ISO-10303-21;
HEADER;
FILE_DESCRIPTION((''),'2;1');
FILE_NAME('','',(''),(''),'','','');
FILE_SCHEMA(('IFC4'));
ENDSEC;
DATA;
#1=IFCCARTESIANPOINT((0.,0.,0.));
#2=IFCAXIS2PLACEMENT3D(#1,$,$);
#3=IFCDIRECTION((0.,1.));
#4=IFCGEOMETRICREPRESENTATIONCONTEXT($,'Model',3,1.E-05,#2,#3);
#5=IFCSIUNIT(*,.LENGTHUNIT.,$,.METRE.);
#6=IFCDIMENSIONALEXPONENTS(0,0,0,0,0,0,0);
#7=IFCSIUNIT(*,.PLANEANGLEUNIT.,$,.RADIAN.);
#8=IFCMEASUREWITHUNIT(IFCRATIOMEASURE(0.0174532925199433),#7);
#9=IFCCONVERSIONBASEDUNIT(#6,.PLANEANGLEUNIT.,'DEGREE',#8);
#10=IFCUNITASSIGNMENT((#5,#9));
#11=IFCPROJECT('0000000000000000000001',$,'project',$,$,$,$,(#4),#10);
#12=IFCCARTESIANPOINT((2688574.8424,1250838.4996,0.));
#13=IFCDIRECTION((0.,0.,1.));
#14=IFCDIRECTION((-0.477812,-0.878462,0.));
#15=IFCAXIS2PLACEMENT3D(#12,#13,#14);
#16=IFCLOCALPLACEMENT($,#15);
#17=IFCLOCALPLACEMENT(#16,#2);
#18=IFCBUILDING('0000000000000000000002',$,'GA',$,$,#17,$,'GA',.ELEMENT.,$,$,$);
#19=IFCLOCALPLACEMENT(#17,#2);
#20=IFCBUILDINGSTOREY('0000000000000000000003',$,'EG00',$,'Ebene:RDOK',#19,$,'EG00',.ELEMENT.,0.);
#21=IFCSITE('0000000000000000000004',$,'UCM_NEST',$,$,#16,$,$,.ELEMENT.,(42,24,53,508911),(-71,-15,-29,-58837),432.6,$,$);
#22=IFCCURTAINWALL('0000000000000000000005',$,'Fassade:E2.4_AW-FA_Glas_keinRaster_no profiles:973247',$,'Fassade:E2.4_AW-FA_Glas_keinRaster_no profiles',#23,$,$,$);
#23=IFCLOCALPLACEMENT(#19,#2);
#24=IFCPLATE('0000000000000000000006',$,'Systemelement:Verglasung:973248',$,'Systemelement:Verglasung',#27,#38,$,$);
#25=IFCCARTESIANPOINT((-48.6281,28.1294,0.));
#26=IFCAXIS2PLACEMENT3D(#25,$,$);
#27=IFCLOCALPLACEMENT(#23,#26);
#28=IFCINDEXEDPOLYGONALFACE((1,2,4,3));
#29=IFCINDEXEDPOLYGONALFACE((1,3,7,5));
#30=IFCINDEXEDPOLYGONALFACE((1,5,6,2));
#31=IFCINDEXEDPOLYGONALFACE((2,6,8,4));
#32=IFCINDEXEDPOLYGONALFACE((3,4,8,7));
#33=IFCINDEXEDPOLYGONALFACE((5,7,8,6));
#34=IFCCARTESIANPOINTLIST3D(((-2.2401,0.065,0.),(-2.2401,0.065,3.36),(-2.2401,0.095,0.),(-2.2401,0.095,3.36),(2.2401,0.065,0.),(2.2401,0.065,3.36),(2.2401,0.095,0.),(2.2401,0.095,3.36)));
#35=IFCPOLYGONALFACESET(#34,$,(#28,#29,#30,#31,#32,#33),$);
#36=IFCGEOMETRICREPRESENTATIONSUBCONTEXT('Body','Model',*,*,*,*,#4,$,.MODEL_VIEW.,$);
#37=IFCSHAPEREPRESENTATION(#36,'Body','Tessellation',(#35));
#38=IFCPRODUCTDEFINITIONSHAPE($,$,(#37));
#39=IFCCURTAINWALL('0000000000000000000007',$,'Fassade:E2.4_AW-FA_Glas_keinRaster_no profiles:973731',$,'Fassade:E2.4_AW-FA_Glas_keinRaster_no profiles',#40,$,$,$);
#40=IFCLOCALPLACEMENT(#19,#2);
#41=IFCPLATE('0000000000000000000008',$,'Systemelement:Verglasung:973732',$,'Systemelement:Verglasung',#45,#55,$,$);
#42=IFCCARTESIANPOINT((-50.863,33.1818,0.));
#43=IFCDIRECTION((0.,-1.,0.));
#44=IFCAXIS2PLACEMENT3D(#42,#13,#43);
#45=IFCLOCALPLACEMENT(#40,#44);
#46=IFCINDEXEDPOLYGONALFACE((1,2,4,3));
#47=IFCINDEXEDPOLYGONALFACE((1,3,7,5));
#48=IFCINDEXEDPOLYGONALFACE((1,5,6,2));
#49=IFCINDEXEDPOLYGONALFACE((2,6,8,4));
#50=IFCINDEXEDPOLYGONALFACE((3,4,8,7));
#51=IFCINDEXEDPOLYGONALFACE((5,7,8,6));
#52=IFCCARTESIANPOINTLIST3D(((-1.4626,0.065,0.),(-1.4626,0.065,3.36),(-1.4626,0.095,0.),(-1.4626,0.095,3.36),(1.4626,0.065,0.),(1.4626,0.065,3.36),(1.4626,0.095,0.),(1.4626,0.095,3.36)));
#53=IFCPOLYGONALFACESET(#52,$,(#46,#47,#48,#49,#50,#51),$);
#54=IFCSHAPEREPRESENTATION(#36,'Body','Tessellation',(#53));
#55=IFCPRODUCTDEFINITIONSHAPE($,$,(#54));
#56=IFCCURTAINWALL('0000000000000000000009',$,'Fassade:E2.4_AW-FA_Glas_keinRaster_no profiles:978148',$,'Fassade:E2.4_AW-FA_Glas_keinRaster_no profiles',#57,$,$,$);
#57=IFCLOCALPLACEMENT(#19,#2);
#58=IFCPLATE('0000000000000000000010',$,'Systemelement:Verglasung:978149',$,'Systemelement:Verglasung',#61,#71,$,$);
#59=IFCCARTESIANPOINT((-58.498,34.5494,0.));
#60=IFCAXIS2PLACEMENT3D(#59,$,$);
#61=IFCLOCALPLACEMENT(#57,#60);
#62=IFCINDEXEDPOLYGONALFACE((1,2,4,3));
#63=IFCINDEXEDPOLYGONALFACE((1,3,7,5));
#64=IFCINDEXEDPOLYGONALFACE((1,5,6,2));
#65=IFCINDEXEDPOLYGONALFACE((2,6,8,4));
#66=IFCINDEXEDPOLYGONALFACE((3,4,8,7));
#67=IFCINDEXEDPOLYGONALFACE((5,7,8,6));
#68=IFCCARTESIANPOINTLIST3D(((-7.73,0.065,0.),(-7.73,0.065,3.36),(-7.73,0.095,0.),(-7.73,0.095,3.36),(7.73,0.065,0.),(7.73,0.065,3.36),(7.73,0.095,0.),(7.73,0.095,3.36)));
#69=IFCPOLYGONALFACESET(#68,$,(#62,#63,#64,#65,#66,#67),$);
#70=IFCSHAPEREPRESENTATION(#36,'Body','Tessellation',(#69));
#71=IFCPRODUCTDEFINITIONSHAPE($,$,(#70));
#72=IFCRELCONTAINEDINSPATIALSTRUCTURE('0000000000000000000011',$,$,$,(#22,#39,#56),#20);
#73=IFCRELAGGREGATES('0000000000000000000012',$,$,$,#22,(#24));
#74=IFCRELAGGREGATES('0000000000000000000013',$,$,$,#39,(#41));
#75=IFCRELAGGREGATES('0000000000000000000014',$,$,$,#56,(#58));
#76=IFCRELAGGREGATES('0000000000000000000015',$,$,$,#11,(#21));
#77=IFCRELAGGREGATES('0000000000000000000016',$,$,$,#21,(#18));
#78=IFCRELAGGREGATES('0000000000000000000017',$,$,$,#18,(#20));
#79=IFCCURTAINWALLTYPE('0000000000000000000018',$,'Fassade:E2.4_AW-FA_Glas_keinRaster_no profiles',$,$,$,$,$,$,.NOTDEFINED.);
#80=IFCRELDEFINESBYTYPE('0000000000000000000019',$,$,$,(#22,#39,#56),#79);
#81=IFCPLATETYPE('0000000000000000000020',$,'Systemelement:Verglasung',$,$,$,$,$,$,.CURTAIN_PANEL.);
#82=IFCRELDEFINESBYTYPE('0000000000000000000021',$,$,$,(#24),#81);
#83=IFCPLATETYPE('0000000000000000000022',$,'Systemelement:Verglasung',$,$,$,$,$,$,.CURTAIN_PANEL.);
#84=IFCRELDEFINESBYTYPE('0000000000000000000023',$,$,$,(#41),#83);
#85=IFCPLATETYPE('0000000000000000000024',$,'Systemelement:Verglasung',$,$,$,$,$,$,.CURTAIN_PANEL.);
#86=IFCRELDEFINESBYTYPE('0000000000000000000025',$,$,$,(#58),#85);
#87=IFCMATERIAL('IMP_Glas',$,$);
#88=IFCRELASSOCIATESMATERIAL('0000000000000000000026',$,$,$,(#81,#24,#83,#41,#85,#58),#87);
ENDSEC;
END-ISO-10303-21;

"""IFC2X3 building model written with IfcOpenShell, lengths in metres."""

from ifc_helpers import new_model, entity, si_unit, converted_unit, direction, frame, frame_2d, origin, place, context, subcontext, project, spatial, rectangle, extrude, source, transform, mapped, material, type_object, type_shapes, element, aggregate, save


model = new_model("IFC2X3")

# Units and contexts
model_context = context("Model", 3, precision=1e-05, world=origin(), true_north=direction((0.0, 1.0)))
body_context = subcontext(model_context, "Body", "Model", "MODEL_VIEW")
ifc_project = project(units=[si_unit("LENGTHUNIT", "METRE"), converted_unit("PLANEANGLEUNIT", "DEGREE", entity("IfcRatioMeasure", 0.0174532925199433), si_unit("PLANEANGLEUNIT", "RADIAN"), dimensions=[0, 0, 0, 0, 0, 0, 0])], contexts=[model_context])

# Site, building, storey
site_placement = place(None, frame((2688574.8424, 1250838.4996, 0.0), z_axis=(0.0, 0.0, 1.0), x_axis=(-0.477812, -0.878462, 0.0)))
site = spatial("IfcSite", under=ifc_project, at=site_placement, Name="UCM_NEST", CompositionType="ELEMENT", RefLatitude=(42, 24, 53, 508911), RefLongitude=(-71, -15, -29, -58837), RefElevation=432.6)
building_placement = place(site_placement, origin())
building = spatial("IfcBuilding", under=site, at=building_placement, Name="GA", LongName="GA", CompositionType="ELEMENT")
storey_placement = place(building_placement, origin())
storey = spatial("IfcBuildingStorey", under=building, at=storey_placement, Name="EG00", ObjectType="Ebene:RDOK", LongName="EG00", CompositionType="ELEMENT", Elevation=0.0)

# Curtain walls, plates
curtain_wall_type = type_object("IfcCurtainWallType", Name="Fassade:E2.4_AW-FA_Glas_keinRaster_no profiles", PredefinedType="NOTDEFINED")
curtain_wall_1_placement = place(storey_placement, origin())
curtain_wall_1 = element("IfcCurtainWall", 1, at=curtain_wall_1_placement, inside=storey, type_object=curtain_wall_type, Name="Fassade:E2.4_AW-FA_Glas_keinRaster_no profiles:973247", ObjectType="Fassade:E2.4_AW-FA_Glas_keinRaster_no profiles")
ifc_material_1 = material(Name="IMP_Glas")
plate_type_1 = type_object("IfcPlateType", Name="Systemelement:Verglasung", PredefinedType="CURTAIN_PANEL", material=ifc_material_1)
shared_shape_1 = source(origin(), body_context, "Body", "SweptSolid", [
    extrude(rectangle(XDim=0.03, YDim=4.4801, at=frame_2d((0.0, 0.0), x_axis=(1.0, 0.0))), frame((0.0, 0.08, 0.0), z_axis=(0.0, 0.0, 1.0), x_axis=(0.0, 1.0, 0.0)), (0.0, 0.0, 1.0), 3.36),
])
type_shapes(plate_type_1, [shared_shape_1])
plate_1_placement = place(curtain_wall_1_placement, frame((-48.6281, 28.1294, 0.0)))
plate_1 = element("IfcPlate", 2, at=plate_1_placement, type_object=plate_type_1, material=ifc_material_1, Name="Systemelement:Verglasung:973248", ObjectType="Systemelement:Verglasung", context=body_context, shape_type="MappedRepresentation", body=[
    mapped(shared_shape_1, transform((0.0, 0.0, 0.0), scale=1.0)),
])
aggregate(curtain_wall_1, [plate_1])
curtain_wall_2_placement = place(storey_placement, origin())
curtain_wall_2 = element("IfcCurtainWall", 3, at=curtain_wall_2_placement, inside=storey, type_object=curtain_wall_type, Name="Fassade:E2.4_AW-FA_Glas_keinRaster_no profiles:973731", ObjectType="Fassade:E2.4_AW-FA_Glas_keinRaster_no profiles")
plate_type_2 = type_object("IfcPlateType", Name="Systemelement:Verglasung", PredefinedType="CURTAIN_PANEL", material=ifc_material_1)
shared_shape_2 = source(origin(), body_context, "Body", "SweptSolid", [
    extrude(rectangle(XDim=0.03, YDim=2.9253, at=frame_2d((0.0, 0.0), x_axis=(1.0, 0.0))), frame((0.0, 0.08, 0.0), z_axis=(0.0, 0.0, 1.0), x_axis=(0.0, 1.0, 0.0)), (0.0, 0.0, 1.0), 3.36),
])
type_shapes(plate_type_2, [shared_shape_2])
plate_2_placement = place(curtain_wall_2_placement, frame((-50.863, 33.1818, 0.0), z_axis=(0.0, 0.0, 1.0), x_axis=(0.0, -1.0, 0.0)))
plate_2 = element("IfcPlate", 4, at=plate_2_placement, type_object=plate_type_2, material=ifc_material_1, Name="Systemelement:Verglasung:973732", ObjectType="Systemelement:Verglasung", context=body_context, shape_type="MappedRepresentation", body=[
    mapped(shared_shape_2, transform((0.0, 0.0, 0.0), scale=1.0)),
])
aggregate(curtain_wall_2, [plate_2])
curtain_wall_3_placement = place(storey_placement, origin())
curtain_wall_3 = element("IfcCurtainWall", 5, at=curtain_wall_3_placement, inside=storey, type_object=curtain_wall_type, Name="Fassade:E2.4_AW-FA_Glas_keinRaster_no profiles:978148", ObjectType="Fassade:E2.4_AW-FA_Glas_keinRaster_no profiles")
plate_type_3 = type_object("IfcPlateType", Name="Systemelement:Verglasung", PredefinedType="CURTAIN_PANEL", material=ifc_material_1)
shared_shape_3 = source(origin(), body_context, "Body", "SweptSolid", [
    extrude(rectangle(XDim=0.03, YDim=15.46, at=frame_2d((0.0, 0.0), x_axis=(1.0, 0.0))), frame((0.0, 0.08, 0.0), z_axis=(0.0, 0.0, 1.0), x_axis=(0.0, 1.0, 0.0)), (0.0, 0.0, 1.0), 3.36),
])
type_shapes(plate_type_3, [shared_shape_3])
plate_3_placement = place(curtain_wall_3_placement, frame((-58.498, 34.5494, 0.0)))
plate_3 = element("IfcPlate", 6, at=plate_3_placement, type_object=plate_type_3, material=ifc_material_1, Name="Systemelement:Verglasung:978149", ObjectType="Systemelement:Verglasung", context=body_context, shape_type="MappedRepresentation", body=[
    mapped(shared_shape_3, transform((0.0, 0.0, 0.0), scale=1.0)),
])
aggregate(curtain_wall_3, [plate_3])

save(model, "model.ifc")
